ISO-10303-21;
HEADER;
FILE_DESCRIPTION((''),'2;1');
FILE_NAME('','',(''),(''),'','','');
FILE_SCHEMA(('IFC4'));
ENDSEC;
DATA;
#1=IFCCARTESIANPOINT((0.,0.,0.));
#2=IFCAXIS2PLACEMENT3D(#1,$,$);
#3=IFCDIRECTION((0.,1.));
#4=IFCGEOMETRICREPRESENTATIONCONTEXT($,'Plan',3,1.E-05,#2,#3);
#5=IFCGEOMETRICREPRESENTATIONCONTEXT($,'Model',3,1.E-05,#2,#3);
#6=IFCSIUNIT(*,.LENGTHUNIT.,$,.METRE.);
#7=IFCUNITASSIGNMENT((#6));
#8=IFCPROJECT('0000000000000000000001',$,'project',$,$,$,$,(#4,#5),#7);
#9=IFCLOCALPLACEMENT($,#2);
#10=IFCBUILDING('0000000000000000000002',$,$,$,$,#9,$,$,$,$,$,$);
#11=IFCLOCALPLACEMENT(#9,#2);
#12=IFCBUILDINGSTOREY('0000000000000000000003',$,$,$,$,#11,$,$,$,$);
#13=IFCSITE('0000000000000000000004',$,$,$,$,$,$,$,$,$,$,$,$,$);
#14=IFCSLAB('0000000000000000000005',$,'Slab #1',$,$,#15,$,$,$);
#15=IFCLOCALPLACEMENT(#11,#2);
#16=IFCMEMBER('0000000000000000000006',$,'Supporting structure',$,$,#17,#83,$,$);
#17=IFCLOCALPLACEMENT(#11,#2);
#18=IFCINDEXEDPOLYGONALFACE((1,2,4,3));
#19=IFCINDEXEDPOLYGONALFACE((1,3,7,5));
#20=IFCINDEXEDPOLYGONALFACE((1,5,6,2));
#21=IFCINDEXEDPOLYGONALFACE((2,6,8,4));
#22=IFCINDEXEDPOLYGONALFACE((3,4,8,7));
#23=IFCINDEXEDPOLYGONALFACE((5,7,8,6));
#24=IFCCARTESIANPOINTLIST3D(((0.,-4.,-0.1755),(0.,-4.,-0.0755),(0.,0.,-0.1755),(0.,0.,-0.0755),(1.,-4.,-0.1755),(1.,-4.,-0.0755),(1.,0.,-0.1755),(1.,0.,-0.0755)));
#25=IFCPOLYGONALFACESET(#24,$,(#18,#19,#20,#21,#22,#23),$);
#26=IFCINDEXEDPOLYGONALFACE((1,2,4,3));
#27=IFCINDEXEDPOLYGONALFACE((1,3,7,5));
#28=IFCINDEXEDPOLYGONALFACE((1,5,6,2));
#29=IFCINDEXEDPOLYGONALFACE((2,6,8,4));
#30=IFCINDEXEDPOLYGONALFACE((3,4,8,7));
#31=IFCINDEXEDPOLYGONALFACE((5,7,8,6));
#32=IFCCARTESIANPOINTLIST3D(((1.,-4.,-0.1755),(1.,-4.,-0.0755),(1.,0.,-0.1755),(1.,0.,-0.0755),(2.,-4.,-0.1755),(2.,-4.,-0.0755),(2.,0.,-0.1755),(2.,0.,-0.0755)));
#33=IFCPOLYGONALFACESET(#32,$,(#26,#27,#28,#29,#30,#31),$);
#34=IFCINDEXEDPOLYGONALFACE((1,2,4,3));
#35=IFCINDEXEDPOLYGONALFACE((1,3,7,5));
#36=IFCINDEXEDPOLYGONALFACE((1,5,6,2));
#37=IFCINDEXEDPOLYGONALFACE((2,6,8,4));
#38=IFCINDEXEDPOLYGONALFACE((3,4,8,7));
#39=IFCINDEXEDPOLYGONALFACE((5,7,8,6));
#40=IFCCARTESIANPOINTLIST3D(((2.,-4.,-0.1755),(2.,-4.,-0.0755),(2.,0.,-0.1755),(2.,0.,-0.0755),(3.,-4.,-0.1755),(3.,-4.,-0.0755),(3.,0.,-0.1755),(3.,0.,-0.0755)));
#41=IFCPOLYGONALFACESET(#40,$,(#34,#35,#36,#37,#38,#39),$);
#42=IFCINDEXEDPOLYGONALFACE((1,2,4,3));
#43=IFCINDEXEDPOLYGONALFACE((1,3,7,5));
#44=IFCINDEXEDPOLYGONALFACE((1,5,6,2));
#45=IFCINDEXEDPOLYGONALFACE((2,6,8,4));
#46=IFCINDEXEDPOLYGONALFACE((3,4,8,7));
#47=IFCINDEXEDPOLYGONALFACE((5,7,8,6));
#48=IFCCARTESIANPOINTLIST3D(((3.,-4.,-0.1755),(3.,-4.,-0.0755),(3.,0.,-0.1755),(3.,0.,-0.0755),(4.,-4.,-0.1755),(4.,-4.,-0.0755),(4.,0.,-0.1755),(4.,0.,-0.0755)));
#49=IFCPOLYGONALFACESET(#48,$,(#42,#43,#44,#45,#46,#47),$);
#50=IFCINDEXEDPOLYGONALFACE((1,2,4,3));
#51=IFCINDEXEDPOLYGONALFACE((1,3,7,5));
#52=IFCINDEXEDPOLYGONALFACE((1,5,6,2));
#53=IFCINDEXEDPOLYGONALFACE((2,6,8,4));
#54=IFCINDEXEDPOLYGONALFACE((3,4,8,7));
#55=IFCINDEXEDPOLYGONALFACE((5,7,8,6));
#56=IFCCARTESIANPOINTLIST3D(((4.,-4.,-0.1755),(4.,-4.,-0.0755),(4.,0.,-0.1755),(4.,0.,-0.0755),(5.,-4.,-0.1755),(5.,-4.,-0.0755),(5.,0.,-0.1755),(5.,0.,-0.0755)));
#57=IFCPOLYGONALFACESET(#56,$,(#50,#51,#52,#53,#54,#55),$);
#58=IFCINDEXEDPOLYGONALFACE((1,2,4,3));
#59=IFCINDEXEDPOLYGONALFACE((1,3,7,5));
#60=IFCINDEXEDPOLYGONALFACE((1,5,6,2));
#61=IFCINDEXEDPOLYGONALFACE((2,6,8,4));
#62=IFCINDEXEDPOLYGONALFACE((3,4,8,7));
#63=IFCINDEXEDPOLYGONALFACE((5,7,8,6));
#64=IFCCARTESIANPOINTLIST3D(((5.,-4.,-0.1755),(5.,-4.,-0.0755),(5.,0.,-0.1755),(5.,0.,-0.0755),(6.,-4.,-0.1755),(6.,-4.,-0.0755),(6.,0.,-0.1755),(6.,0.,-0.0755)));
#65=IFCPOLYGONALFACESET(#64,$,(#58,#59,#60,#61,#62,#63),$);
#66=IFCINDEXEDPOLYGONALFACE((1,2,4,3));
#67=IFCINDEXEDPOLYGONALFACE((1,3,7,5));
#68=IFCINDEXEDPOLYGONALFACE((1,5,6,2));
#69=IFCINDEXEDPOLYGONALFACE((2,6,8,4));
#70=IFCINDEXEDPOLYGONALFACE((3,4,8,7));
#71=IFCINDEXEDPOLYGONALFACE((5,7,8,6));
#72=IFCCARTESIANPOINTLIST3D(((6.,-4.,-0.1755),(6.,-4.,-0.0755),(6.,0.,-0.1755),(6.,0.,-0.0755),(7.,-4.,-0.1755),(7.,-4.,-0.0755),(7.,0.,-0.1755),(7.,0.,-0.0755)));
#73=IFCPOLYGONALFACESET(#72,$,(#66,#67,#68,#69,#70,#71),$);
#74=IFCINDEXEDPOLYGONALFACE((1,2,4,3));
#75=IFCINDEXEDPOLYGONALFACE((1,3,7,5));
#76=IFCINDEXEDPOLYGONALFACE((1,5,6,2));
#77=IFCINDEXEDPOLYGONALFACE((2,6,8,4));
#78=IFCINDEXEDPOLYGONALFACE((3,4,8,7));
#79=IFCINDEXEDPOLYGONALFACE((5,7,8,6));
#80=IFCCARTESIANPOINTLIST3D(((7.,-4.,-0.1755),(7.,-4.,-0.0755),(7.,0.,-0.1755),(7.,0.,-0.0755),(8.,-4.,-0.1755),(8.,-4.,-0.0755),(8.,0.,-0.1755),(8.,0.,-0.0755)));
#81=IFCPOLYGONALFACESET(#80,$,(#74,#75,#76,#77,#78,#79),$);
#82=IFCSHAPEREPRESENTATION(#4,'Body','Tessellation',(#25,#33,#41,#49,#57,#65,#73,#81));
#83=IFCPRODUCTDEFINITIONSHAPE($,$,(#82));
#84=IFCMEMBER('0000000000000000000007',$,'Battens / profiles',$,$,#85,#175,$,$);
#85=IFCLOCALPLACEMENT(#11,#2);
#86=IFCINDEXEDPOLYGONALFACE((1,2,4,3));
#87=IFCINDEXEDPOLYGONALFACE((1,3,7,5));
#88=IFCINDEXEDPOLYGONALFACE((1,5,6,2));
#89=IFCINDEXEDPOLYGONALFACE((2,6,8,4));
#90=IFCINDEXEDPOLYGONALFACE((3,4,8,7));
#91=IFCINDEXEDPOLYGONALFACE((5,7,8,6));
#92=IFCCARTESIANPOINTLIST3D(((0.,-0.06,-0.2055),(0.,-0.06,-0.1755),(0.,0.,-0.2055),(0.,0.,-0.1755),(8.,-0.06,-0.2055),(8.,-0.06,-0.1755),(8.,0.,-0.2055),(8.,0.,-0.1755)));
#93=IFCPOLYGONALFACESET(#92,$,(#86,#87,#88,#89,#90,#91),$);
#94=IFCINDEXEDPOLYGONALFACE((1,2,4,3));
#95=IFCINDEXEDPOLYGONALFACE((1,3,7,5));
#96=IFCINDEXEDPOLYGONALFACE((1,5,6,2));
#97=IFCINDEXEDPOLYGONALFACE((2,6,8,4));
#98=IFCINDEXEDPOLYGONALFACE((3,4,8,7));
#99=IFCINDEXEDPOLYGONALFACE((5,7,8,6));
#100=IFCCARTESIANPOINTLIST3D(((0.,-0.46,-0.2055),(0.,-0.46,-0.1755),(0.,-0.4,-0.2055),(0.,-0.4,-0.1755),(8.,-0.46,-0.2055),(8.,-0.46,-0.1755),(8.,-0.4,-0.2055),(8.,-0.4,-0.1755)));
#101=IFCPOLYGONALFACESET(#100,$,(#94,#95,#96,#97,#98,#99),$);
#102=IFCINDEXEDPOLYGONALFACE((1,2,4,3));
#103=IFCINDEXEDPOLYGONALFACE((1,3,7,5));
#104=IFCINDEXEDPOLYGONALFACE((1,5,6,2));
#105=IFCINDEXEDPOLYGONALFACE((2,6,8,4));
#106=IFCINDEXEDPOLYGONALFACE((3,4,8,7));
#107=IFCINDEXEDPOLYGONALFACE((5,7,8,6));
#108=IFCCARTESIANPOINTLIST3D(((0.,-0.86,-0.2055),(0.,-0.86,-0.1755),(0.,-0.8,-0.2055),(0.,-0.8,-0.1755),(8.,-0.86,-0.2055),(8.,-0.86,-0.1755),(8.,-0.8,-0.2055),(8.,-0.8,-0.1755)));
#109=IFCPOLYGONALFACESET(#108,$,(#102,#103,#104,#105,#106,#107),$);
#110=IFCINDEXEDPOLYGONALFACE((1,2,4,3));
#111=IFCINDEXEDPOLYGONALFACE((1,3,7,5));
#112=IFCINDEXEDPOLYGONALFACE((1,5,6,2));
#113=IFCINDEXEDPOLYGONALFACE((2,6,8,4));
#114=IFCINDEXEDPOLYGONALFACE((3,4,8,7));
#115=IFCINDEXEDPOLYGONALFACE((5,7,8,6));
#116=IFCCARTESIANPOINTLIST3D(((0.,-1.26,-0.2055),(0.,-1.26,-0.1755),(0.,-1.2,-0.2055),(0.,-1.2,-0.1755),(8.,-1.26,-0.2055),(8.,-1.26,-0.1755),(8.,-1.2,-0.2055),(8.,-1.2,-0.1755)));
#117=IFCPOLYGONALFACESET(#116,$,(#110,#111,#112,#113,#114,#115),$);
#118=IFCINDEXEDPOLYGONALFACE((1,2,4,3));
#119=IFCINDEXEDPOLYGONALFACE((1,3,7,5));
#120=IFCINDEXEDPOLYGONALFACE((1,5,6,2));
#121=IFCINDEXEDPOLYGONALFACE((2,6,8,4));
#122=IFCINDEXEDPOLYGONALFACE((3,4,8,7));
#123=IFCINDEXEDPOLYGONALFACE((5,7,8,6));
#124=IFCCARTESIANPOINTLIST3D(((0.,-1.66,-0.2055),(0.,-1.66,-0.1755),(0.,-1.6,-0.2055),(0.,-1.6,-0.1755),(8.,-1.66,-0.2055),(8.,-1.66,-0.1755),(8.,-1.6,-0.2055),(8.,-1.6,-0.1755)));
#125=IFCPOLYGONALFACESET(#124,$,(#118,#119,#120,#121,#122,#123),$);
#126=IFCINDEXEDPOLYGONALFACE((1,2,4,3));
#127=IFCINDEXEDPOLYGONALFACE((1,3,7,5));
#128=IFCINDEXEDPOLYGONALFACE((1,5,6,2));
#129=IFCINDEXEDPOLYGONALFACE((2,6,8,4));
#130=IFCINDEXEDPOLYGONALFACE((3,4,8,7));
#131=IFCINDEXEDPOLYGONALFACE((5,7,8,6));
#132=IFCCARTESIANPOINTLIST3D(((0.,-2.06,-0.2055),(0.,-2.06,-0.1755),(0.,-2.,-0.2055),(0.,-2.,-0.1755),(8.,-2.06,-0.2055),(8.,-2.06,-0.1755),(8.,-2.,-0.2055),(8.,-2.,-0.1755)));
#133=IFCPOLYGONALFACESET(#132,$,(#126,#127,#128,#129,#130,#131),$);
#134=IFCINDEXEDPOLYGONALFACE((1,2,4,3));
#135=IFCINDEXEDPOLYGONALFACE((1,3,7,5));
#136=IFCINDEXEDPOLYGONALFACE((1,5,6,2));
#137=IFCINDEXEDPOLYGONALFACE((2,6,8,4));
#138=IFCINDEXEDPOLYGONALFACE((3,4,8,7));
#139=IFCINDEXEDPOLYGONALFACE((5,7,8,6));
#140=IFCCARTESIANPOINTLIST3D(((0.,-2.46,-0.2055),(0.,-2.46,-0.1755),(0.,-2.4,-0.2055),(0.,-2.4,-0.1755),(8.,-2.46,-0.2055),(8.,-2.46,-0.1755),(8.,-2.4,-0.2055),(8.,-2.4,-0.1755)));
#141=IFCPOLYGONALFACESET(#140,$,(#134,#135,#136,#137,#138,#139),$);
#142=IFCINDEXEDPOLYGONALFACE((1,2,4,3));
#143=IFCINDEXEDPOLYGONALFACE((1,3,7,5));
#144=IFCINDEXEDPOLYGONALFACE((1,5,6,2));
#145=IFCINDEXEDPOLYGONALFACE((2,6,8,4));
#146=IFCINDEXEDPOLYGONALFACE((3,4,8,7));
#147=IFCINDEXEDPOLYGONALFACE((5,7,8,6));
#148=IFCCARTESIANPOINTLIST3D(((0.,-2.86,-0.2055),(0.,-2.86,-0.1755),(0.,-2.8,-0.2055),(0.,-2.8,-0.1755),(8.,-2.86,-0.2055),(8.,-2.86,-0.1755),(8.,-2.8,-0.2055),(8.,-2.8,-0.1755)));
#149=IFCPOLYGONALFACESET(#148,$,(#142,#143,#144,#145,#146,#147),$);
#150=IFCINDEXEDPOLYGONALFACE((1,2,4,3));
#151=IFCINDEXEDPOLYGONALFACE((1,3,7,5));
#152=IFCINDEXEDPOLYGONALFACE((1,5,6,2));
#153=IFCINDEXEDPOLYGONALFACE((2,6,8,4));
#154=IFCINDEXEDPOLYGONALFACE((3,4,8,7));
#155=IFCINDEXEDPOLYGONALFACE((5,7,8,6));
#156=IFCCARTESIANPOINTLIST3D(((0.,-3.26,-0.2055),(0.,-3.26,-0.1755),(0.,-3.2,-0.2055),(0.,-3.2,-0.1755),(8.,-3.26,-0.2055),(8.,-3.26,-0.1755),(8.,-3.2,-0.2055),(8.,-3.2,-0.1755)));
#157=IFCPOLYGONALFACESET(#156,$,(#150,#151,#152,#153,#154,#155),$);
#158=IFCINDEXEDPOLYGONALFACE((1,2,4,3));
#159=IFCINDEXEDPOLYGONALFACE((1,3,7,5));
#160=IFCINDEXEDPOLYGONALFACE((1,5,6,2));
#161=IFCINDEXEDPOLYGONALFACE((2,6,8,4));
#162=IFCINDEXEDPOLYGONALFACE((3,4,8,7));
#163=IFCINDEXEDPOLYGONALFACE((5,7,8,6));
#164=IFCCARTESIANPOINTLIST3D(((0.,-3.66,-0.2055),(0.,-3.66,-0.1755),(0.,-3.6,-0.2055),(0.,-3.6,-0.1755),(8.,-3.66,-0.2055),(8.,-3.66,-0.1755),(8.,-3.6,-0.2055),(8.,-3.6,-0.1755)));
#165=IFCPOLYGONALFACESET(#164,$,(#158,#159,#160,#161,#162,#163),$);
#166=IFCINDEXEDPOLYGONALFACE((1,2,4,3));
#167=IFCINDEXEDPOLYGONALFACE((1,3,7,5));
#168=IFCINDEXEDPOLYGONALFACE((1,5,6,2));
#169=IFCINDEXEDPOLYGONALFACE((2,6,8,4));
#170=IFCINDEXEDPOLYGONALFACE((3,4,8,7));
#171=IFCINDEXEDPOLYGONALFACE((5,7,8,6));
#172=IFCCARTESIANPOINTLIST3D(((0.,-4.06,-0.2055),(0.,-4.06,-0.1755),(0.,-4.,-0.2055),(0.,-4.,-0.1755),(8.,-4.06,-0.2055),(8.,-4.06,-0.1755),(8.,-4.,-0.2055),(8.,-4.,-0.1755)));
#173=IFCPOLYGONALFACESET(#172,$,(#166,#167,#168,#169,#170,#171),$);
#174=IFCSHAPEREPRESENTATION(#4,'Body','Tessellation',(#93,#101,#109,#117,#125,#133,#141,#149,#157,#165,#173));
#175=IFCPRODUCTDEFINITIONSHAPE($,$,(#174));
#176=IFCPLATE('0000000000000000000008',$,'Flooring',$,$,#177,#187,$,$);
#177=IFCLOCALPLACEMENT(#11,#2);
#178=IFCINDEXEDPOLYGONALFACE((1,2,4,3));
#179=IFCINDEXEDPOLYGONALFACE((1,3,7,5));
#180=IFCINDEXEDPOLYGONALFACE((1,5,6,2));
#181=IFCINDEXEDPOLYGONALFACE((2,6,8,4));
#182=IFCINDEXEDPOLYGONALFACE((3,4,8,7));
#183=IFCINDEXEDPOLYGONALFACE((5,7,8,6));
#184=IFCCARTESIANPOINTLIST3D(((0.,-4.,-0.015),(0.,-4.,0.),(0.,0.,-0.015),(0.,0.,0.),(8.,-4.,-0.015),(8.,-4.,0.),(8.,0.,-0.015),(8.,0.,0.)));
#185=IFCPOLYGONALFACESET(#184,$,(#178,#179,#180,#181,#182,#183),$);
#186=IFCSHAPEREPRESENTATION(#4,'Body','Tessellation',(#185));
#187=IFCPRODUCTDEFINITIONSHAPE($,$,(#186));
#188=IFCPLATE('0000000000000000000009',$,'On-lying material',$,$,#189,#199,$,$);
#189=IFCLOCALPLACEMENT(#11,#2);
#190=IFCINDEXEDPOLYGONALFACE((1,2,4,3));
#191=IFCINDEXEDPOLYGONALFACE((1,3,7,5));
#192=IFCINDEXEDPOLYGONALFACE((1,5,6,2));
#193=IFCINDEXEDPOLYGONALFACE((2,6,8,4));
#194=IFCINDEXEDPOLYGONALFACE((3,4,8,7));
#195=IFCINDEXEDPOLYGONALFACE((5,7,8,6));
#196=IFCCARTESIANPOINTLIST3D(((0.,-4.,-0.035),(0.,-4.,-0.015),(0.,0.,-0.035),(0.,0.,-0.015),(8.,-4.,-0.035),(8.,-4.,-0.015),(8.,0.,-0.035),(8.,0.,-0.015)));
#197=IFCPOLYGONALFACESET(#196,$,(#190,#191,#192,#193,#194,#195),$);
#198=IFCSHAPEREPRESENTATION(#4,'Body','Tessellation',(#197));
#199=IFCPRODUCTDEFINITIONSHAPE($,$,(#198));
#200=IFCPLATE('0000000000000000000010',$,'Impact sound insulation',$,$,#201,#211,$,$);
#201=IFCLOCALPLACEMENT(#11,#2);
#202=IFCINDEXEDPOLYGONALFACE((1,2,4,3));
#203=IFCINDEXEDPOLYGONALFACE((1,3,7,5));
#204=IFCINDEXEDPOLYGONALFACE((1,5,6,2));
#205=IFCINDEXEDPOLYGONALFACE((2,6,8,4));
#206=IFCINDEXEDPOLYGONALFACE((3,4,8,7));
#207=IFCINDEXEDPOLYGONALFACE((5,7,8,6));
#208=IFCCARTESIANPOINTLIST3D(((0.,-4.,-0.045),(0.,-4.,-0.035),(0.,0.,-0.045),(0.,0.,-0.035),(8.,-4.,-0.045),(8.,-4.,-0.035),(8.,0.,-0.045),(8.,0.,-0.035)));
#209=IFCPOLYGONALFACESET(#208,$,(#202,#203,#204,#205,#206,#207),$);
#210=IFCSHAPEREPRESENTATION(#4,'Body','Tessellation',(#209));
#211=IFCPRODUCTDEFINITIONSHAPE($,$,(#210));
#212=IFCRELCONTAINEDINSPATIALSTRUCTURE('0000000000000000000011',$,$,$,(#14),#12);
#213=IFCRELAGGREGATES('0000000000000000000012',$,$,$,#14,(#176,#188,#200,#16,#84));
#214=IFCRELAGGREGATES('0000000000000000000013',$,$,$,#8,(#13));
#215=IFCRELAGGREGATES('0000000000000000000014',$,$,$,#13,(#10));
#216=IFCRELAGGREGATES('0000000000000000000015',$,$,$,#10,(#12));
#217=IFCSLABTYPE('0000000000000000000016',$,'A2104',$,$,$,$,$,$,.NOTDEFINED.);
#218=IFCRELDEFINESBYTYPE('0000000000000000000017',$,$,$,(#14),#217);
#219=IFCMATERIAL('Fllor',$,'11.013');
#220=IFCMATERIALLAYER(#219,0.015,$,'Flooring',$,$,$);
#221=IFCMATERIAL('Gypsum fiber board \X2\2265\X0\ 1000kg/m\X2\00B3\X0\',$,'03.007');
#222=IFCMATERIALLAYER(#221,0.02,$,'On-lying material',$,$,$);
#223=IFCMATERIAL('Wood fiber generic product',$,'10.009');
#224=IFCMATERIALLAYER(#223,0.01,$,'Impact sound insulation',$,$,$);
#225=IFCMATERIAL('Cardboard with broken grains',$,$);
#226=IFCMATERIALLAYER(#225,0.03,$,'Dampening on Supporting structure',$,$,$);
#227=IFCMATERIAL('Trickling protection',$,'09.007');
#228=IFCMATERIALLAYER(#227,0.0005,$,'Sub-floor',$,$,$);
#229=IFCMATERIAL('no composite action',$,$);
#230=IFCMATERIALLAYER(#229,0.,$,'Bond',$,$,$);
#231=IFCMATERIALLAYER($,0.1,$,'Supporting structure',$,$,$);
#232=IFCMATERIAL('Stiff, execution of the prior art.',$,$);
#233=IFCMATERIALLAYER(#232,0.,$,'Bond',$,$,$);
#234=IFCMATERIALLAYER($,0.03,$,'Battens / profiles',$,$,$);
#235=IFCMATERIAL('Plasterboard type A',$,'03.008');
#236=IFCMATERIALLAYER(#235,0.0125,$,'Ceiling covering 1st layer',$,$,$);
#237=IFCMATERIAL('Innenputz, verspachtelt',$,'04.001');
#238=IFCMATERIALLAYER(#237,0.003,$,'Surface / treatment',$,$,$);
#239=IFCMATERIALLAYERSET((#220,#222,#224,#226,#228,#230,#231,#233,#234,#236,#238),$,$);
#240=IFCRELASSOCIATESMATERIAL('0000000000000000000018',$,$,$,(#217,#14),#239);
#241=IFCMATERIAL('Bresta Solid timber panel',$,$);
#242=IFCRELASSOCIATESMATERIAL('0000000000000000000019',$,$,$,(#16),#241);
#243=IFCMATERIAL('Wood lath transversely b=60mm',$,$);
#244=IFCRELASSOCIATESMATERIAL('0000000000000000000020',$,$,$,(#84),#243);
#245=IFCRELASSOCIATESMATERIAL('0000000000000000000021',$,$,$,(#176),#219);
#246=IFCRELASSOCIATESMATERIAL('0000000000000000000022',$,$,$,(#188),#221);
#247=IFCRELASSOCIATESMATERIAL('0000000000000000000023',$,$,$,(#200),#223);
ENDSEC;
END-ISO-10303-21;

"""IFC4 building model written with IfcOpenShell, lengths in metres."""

from ifc_helpers import new_model, si_unit, direction, frame, frame_2d, origin, origin_with_axes, place, context, project, spatial, rectangle, extrude, material, layer, layer_set, type_object, element, aggregate, save


model = new_model("IFC4")

# Units and contexts
plan_context = context("Plan", 3, precision=1e-05, world=origin(), true_north=direction((0.0, 1.0)))
model_context = context("Model", 3, precision=1e-05, world=origin(), true_north=direction((0.0, 1.0)))
ifc_project = project(units=[si_unit("LENGTHUNIT", "METRE")], contexts=[plan_context, model_context])

# Site, building, storey
site = spatial("IfcSite", under=ifc_project)
building_placement = place(None, origin())
building = spatial("IfcBuilding", under=site, at=building_placement)
storey_placement = place(building_placement, origin())
storey = spatial("IfcBuildingStorey", under=building, at=storey_placement)

# Slab, members, plates
ifc_material_1 = material(Name="Fllor", Category="11.013")
ifc_layer_1 = layer(ifc_material_1, 0.015, Name="Flooring")
ifc_material_2 = material(Name="Gypsum fiber board ≥ 1000kg/m³", Category="03.007")
ifc_layer_2 = layer(ifc_material_2, 0.02, Name="On-lying material")
ifc_material_3 = material(Name="Wood fiber generic product", Category="10.009")
ifc_layer_3 = layer(ifc_material_3, 0.01, Name="Impact sound insulation")
ifc_material_4 = material(Name="Cardboard with broken grains")
ifc_layer_4 = layer(ifc_material_4, 0.03, Name="Dampening on Supporting structure")
ifc_material_5 = material(Name="Trickling protection", Category="09.007")
ifc_layer_5 = layer(ifc_material_5, 0.0005, Name="Sub-floor")
ifc_material_6 = material(Name="no composite action")
ifc_layer_6 = layer(ifc_material_6, 0.0, Name="Bond")
ifc_layer_7 = layer(None, 0.1, Name="Supporting structure")
ifc_material_7 = material(Name="Stiff, execution of the prior art.")
ifc_layer_8 = layer(ifc_material_7, 0.0, Name="Bond")
ifc_layer_9 = layer(None, 0.03, Name="Battens / profiles")
ifc_material_8 = material(Name="Plasterboard type A", Category="03.008")
ifc_layer_10 = layer(ifc_material_8, 0.0125, Name="Ceiling covering 1st layer")
ifc_material_9 = material(Name="Innenputz, verspachtelt", Category="04.001")
ifc_layer_11 = layer(ifc_material_9, 0.003, Name="Surface / treatment")
ifc_layer_set = layer_set([ifc_layer_1, ifc_layer_2, ifc_layer_3, ifc_layer_4, ifc_layer_5, ifc_layer_6, ifc_layer_7, ifc_layer_8, ifc_layer_9, ifc_layer_10, ifc_layer_11])
slab_type = type_object("IfcSlabType", Name="A2104", PredefinedType="NOTDEFINED", material=ifc_layer_set)
slab_placement = place(None, frame((0.0, 0.0, 0.0), z_axis=(0.0, 0.0, -1.0), x_axis=(1.0, 0.0, 0.0)))
slab = element("IfcSlab", 1, at=slab_placement, inside=storey, type_object=slab_type, material=ifc_layer_set, Name="Slab #1")
ifc_material_10 = material(Name="Bresta Solid timber panel")
member_1_placement = place(slab_placement, origin())
member_1 = element("IfcMember", 2, at=member_1_placement, material=ifc_material_10, Name="Supporting structure", context=plan_context, shape_type="SweptSolid", body=[
    extrude(rectangle(XDim=1.0, YDim=0.1, at=frame_2d((0.5, 0.05), x_axis=(1.0, 0.0))), frame((0.0, 4.0, 0.0755), z_axis=(0.0, -1.0, 0.0), x_axis=(1.0, 0.0, 0.0)), (0.0, 0.0, 1.0), 4.0),
    extrude(rectangle(XDim=1.0, YDim=0.1, at=frame_2d((0.5, 0.05), x_axis=(1.0, 0.0))), frame((1.0, 4.0, 0.0755), z_axis=(0.0, -1.0, 0.0), x_axis=(1.0, 0.0, 0.0)), (0.0, 0.0, 1.0), 4.0),
    extrude(rectangle(XDim=1.0, YDim=0.1, at=frame_2d((0.5, 0.05), x_axis=(1.0, 0.0))), frame((2.0, 4.0, 0.0755), z_axis=(0.0, -1.0, 0.0), x_axis=(1.0, 0.0, 0.0)), (0.0, 0.0, 1.0), 4.0),
    extrude(rectangle(XDim=1.0, YDim=0.1, at=frame_2d((0.5, 0.05), x_axis=(1.0, 0.0))), frame((3.0, 4.0, 0.0755), z_axis=(0.0, -1.0, 0.0), x_axis=(1.0, 0.0, 0.0)), (0.0, 0.0, 1.0), 4.0),
    extrude(rectangle(XDim=1.0, YDim=0.1, at=frame_2d((0.5, 0.05), x_axis=(1.0, 0.0))), frame((4.0, 4.0, 0.0755), z_axis=(0.0, -1.0, 0.0), x_axis=(1.0, 0.0, 0.0)), (0.0, 0.0, 1.0), 4.0),
    extrude(rectangle(XDim=1.0, YDim=0.1, at=frame_2d((0.5, 0.05), x_axis=(1.0, 0.0))), frame((5.0, 4.0, 0.0755), z_axis=(0.0, -1.0, 0.0), x_axis=(1.0, 0.0, 0.0)), (0.0, 0.0, 1.0), 4.0),
    extrude(rectangle(XDim=1.0, YDim=0.1, at=frame_2d((0.5, 0.05), x_axis=(1.0, 0.0))), frame((6.0, 4.0, 0.0755), z_axis=(0.0, -1.0, 0.0), x_axis=(1.0, 0.0, 0.0)), (0.0, 0.0, 1.0), 4.0),
    extrude(rectangle(XDim=1.0, YDim=0.1, at=frame_2d((0.5, 0.05), x_axis=(1.0, 0.0))), frame((7.0, 4.0, 0.0755), z_axis=(0.0, -1.0, 0.0), x_axis=(1.0, 0.0, 0.0)), (0.0, 0.0, 1.0), 4.0),
])
ifc_material_11 = material(Name="Wood lath transversely b=60mm")
member_2_placement = place(slab_placement, origin())
member_2 = element("IfcMember", 3, at=member_2_placement, material=ifc_material_11, Name="Battens / profiles", context=plan_context, shape_type="SweptSolid", body=[
    extrude(rectangle(XDim=0.06, YDim=0.03, at=frame_2d((0.03, 0.015), x_axis=(1.0, 0.0))), frame((0.0, 0.0, 0.1755), z_axis=(1.0, 0.0, 0.0), x_axis=(0.0, 1.0, 0.0)), (0.0, 0.0, 1.0), 8.0),
    extrude(rectangle(XDim=0.06, YDim=0.03, at=frame_2d((0.03, 0.015), x_axis=(1.0, 0.0))), frame((0.0, 0.4, 0.1755), z_axis=(1.0, 0.0, 0.0), x_axis=(0.0, 1.0, 0.0)), (0.0, 0.0, 1.0), 8.0),
    extrude(rectangle(XDim=0.06, YDim=0.03, at=frame_2d((0.03, 0.015), x_axis=(1.0, 0.0))), frame((0.0, 0.8, 0.1755), z_axis=(1.0, 0.0, 0.0), x_axis=(0.0, 1.0, 0.0)), (0.0, 0.0, 1.0), 8.0),
    extrude(rectangle(XDim=0.06, YDim=0.03, at=frame_2d((0.03, 0.015), x_axis=(1.0, 0.0))), frame((0.0, 1.2, 0.1755), z_axis=(1.0, 0.0, 0.0), x_axis=(0.0, 1.0, 0.0)), (0.0, 0.0, 1.0), 8.0),
    extrude(rectangle(XDim=0.06, YDim=0.03, at=frame_2d((0.03, 0.015), x_axis=(1.0, 0.0))), frame((0.0, 1.6, 0.1755), z_axis=(1.0, 0.0, 0.0), x_axis=(0.0, 1.0, 0.0)), (0.0, 0.0, 1.0), 8.0),
    extrude(rectangle(XDim=0.06, YDim=0.03, at=frame_2d((0.03, 0.015), x_axis=(1.0, 0.0))), frame((0.0, 2.0, 0.1755), z_axis=(1.0, 0.0, 0.0), x_axis=(0.0, 1.0, 0.0)), (0.0, 0.0, 1.0), 8.0),
    extrude(rectangle(XDim=0.06, YDim=0.03, at=frame_2d((0.03, 0.015), x_axis=(1.0, 0.0))), frame((0.0, 2.4, 0.1755), z_axis=(1.0, 0.0, 0.0), x_axis=(0.0, 1.0, 0.0)), (0.0, 0.0, 1.0), 8.0),
    extrude(rectangle(XDim=0.06, YDim=0.03, at=frame_2d((0.03, 0.015), x_axis=(1.0, 0.0))), frame((0.0, 2.8, 0.1755), z_axis=(1.0, 0.0, 0.0), x_axis=(0.0, 1.0, 0.0)), (0.0, 0.0, 1.0), 8.0),
    extrude(rectangle(XDim=0.06, YDim=0.03, at=frame_2d((0.03, 0.015), x_axis=(1.0, 0.0))), frame((0.0, 3.2, 0.1755), z_axis=(1.0, 0.0, 0.0), x_axis=(0.0, 1.0, 0.0)), (0.0, 0.0, 1.0), 8.0),
    extrude(rectangle(XDim=0.06, YDim=0.03, at=frame_2d((0.03, 0.015), x_axis=(1.0, 0.0))), frame((0.0, 3.6, 0.1755), z_axis=(1.0, 0.0, 0.0), x_axis=(0.0, 1.0, 0.0)), (0.0, 0.0, 1.0), 8.0),
    extrude(rectangle(XDim=0.06, YDim=0.03, at=frame_2d((0.03, 0.015), x_axis=(1.0, 0.0))), frame((0.0, 4.0, 0.1755), z_axis=(1.0, 0.0, 0.0), x_axis=(0.0, 1.0, 0.0)), (0.0, 0.0, 1.0), 8.0),
])
plate_1_placement = place(slab_placement, origin())
plate_1 = element("IfcPlate", 4, at=plate_1_placement, material=ifc_material_1, Name="Flooring", context=plan_context, shape_type="SweptSolid", body=[
    extrude(rectangle(XDim=8.0, YDim=4.0, at=frame_2d((4.0, 2.0), x_axis=(1.0, 0.0))), origin_with_axes(), (0.0, 0.0, 1.0), 0.015),
])
plate_2_placement = place(slab_placement, origin())
plate_2 = element("IfcPlate", 5, at=plate_2_placement, material=ifc_material_2, Name="On-lying material", context=plan_context, shape_type="SweptSolid", body=[
    extrude(rectangle(XDim=8.0, YDim=4.0, at=frame_2d((4.0, 2.0), x_axis=(1.0, 0.0))), frame((0.0, 0.0, 0.015), z_axis=(0.0, 0.0, 1.0), x_axis=(1.0, 0.0, 0.0)), (0.0, 0.0, 1.0), 0.02),
])
plate_3_placement = place(slab_placement, origin())
plate_3 = element("IfcPlate", 6, at=plate_3_placement, material=ifc_material_3, Name="Impact sound insulation", context=plan_context, shape_type="SweptSolid", body=[
    extrude(rectangle(XDim=8.0, YDim=4.0, at=frame_2d((4.0, 2.0), x_axis=(1.0, 0.0))), frame((0.0, 0.0, 0.035), z_axis=(0.0, 0.0, 1.0), x_axis=(1.0, 0.0, 0.0)), (0.0, 0.0, 1.0), 0.01),
])
aggregate(slab, [plate_1, plate_2, plate_3, member_1, member_2])

save(model, "model.ifc")
